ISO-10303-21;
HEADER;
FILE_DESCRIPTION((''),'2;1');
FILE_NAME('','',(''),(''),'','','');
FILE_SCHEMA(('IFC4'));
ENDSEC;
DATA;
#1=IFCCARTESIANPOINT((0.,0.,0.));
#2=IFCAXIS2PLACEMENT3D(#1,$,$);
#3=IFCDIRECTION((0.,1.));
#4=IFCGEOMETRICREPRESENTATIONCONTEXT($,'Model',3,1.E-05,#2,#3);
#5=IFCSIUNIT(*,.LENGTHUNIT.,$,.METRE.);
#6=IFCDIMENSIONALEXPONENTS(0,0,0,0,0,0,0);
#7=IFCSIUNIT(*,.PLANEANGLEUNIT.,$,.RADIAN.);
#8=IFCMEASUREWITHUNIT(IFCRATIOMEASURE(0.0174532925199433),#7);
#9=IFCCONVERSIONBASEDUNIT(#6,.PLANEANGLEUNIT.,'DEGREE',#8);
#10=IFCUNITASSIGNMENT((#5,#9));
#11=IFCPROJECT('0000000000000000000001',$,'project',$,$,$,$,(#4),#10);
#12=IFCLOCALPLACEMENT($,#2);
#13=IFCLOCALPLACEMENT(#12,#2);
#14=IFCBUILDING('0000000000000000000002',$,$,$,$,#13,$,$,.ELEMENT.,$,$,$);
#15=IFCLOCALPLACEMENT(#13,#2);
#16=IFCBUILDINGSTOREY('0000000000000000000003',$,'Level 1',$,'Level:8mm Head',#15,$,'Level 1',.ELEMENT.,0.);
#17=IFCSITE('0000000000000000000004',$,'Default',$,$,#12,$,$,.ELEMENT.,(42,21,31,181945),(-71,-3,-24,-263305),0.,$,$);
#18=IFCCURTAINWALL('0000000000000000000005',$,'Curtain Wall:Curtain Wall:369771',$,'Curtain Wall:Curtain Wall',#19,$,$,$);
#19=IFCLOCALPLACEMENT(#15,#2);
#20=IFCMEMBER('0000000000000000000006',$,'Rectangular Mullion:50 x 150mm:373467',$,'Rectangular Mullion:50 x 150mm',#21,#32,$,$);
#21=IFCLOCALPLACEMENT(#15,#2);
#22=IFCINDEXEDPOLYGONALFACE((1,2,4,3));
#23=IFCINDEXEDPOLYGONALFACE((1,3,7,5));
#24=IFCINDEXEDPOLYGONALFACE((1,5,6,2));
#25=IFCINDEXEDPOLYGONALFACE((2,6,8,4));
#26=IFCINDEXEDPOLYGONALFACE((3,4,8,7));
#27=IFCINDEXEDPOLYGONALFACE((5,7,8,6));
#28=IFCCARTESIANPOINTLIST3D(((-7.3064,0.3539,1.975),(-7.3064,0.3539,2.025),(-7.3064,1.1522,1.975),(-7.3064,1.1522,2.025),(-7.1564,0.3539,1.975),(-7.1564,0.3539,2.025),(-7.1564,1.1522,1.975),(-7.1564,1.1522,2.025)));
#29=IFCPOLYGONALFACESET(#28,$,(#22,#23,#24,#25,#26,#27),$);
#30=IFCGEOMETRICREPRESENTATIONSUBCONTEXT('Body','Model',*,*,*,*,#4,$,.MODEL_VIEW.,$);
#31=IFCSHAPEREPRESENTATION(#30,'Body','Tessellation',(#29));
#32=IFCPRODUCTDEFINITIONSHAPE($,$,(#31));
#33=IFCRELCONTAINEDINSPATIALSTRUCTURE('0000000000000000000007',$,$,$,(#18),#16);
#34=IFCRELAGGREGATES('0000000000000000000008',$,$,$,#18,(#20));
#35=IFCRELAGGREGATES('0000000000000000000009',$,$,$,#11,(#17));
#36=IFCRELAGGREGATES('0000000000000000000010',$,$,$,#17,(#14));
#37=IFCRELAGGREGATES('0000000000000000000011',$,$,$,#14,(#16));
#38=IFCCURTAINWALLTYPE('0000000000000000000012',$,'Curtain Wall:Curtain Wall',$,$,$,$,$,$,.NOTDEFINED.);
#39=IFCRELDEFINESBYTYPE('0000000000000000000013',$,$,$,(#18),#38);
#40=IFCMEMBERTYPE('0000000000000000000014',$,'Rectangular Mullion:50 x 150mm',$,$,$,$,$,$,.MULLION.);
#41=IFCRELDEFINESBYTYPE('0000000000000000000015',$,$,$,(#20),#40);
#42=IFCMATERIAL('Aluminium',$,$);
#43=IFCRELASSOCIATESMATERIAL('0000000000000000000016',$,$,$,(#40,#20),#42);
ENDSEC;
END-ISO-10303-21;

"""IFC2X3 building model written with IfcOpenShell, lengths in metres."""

from ifc_helpers import new_model, entity, si_unit, converted_unit, direction, frame, origin, origin_2d_with_axis, place, context, subcontext, project, spatial, rectangle, extrude, source, transform, mapped, material, type_object, type_shapes, element, aggregate, save


model = new_model("IFC2X3")

# Units and contexts
model_context = context("Model", 3, precision=1e-05, world=origin(), true_north=direction((0.0, 1.0)))
body_context = subcontext(model_context, "Body", "Model", "MODEL_VIEW")
ifc_project = project(units=[si_unit("LENGTHUNIT", "METRE"), converted_unit("PLANEANGLEUNIT", "DEGREE", entity("IfcRatioMeasure", 0.0174532925199433), si_unit("PLANEANGLEUNIT", "RADIAN"), dimensions=[0, 0, 0, 0, 0, 0, 0])], contexts=[model_context])

# Site, building, storey
site_placement = place(None, origin())
site = spatial("IfcSite", under=ifc_project, at=site_placement, Name="Default", CompositionType="ELEMENT", RefLatitude=(42, 21, 31, 181945), RefLongitude=(-71, -3, -24, -263305), RefElevation=0.0)
building_placement = place(site_placement, origin())
building = spatial("IfcBuilding", under=site, at=building_placement, CompositionType="ELEMENT")
storey_placement = place(building_placement, origin())
storey = spatial("IfcBuildingStorey", under=building, at=storey_placement, Name="Level 1", ObjectType="Level:8mm Head", LongName="Level 1", CompositionType="ELEMENT", Elevation=0.0)

# Curtain wall, member
curtain_wall_type = type_object("IfcCurtainWallType", Name="Curtain Wall:Curtain Wall", PredefinedType="NOTDEFINED")
ifc_material_1 = material(Name="Aluminium")
curtain_wall_1_placement = place(storey_placement, origin())
curtain_wall_1 = element("IfcCurtainWall", 1, at=curtain_wall_1_placement, inside=storey, type_object=curtain_wall_type, Name="Curtain Wall:Curtain Wall:369771", ObjectType="Curtain Wall:Curtain Wall")
member_type_1 = type_object("IfcMemberType", Name="Rectangular Mullion:50 x 150mm", PredefinedType="MULLION", material=ifc_material_1)
shared_shape_1 = source(origin(), body_context, "Body", "SweptSolid", [
    extrude(rectangle(XDim=0.15, YDim=0.05, at=origin_2d_with_axis()), frame((0.0, 0.0, -0.7983), z_axis=(0.0, 0.0, 1.0), x_axis=(0.0, -1.0, 0.0)), (0.0, 0.0, 1.0), 0.7983),
])
type_shapes(member_type_1, [shared_shape_1])
member_1_placement = place(storey_placement, frame((-7.2314, 0.3539, 2.0), z_axis=(0.0, -1.0, 0.0), x_axis=(0.0, 0.0, 1.0)))
member_1 = element("IfcMember", 2, at=member_1_placement, type_object=member_type_1, material=ifc_material_1, Name="Rectangular Mullion:50 x 150mm:373467", ObjectType="Rectangular Mullion:50 x 150mm", context=body_context, shape_type="MappedRepresentation", body=[
    mapped(shared_shape_1, transform((0.0, 0.0, 0.0), scale=1.0)),
])

aggregate(curtain_wall_1, [member_1])

save(model, "model.ifc")
